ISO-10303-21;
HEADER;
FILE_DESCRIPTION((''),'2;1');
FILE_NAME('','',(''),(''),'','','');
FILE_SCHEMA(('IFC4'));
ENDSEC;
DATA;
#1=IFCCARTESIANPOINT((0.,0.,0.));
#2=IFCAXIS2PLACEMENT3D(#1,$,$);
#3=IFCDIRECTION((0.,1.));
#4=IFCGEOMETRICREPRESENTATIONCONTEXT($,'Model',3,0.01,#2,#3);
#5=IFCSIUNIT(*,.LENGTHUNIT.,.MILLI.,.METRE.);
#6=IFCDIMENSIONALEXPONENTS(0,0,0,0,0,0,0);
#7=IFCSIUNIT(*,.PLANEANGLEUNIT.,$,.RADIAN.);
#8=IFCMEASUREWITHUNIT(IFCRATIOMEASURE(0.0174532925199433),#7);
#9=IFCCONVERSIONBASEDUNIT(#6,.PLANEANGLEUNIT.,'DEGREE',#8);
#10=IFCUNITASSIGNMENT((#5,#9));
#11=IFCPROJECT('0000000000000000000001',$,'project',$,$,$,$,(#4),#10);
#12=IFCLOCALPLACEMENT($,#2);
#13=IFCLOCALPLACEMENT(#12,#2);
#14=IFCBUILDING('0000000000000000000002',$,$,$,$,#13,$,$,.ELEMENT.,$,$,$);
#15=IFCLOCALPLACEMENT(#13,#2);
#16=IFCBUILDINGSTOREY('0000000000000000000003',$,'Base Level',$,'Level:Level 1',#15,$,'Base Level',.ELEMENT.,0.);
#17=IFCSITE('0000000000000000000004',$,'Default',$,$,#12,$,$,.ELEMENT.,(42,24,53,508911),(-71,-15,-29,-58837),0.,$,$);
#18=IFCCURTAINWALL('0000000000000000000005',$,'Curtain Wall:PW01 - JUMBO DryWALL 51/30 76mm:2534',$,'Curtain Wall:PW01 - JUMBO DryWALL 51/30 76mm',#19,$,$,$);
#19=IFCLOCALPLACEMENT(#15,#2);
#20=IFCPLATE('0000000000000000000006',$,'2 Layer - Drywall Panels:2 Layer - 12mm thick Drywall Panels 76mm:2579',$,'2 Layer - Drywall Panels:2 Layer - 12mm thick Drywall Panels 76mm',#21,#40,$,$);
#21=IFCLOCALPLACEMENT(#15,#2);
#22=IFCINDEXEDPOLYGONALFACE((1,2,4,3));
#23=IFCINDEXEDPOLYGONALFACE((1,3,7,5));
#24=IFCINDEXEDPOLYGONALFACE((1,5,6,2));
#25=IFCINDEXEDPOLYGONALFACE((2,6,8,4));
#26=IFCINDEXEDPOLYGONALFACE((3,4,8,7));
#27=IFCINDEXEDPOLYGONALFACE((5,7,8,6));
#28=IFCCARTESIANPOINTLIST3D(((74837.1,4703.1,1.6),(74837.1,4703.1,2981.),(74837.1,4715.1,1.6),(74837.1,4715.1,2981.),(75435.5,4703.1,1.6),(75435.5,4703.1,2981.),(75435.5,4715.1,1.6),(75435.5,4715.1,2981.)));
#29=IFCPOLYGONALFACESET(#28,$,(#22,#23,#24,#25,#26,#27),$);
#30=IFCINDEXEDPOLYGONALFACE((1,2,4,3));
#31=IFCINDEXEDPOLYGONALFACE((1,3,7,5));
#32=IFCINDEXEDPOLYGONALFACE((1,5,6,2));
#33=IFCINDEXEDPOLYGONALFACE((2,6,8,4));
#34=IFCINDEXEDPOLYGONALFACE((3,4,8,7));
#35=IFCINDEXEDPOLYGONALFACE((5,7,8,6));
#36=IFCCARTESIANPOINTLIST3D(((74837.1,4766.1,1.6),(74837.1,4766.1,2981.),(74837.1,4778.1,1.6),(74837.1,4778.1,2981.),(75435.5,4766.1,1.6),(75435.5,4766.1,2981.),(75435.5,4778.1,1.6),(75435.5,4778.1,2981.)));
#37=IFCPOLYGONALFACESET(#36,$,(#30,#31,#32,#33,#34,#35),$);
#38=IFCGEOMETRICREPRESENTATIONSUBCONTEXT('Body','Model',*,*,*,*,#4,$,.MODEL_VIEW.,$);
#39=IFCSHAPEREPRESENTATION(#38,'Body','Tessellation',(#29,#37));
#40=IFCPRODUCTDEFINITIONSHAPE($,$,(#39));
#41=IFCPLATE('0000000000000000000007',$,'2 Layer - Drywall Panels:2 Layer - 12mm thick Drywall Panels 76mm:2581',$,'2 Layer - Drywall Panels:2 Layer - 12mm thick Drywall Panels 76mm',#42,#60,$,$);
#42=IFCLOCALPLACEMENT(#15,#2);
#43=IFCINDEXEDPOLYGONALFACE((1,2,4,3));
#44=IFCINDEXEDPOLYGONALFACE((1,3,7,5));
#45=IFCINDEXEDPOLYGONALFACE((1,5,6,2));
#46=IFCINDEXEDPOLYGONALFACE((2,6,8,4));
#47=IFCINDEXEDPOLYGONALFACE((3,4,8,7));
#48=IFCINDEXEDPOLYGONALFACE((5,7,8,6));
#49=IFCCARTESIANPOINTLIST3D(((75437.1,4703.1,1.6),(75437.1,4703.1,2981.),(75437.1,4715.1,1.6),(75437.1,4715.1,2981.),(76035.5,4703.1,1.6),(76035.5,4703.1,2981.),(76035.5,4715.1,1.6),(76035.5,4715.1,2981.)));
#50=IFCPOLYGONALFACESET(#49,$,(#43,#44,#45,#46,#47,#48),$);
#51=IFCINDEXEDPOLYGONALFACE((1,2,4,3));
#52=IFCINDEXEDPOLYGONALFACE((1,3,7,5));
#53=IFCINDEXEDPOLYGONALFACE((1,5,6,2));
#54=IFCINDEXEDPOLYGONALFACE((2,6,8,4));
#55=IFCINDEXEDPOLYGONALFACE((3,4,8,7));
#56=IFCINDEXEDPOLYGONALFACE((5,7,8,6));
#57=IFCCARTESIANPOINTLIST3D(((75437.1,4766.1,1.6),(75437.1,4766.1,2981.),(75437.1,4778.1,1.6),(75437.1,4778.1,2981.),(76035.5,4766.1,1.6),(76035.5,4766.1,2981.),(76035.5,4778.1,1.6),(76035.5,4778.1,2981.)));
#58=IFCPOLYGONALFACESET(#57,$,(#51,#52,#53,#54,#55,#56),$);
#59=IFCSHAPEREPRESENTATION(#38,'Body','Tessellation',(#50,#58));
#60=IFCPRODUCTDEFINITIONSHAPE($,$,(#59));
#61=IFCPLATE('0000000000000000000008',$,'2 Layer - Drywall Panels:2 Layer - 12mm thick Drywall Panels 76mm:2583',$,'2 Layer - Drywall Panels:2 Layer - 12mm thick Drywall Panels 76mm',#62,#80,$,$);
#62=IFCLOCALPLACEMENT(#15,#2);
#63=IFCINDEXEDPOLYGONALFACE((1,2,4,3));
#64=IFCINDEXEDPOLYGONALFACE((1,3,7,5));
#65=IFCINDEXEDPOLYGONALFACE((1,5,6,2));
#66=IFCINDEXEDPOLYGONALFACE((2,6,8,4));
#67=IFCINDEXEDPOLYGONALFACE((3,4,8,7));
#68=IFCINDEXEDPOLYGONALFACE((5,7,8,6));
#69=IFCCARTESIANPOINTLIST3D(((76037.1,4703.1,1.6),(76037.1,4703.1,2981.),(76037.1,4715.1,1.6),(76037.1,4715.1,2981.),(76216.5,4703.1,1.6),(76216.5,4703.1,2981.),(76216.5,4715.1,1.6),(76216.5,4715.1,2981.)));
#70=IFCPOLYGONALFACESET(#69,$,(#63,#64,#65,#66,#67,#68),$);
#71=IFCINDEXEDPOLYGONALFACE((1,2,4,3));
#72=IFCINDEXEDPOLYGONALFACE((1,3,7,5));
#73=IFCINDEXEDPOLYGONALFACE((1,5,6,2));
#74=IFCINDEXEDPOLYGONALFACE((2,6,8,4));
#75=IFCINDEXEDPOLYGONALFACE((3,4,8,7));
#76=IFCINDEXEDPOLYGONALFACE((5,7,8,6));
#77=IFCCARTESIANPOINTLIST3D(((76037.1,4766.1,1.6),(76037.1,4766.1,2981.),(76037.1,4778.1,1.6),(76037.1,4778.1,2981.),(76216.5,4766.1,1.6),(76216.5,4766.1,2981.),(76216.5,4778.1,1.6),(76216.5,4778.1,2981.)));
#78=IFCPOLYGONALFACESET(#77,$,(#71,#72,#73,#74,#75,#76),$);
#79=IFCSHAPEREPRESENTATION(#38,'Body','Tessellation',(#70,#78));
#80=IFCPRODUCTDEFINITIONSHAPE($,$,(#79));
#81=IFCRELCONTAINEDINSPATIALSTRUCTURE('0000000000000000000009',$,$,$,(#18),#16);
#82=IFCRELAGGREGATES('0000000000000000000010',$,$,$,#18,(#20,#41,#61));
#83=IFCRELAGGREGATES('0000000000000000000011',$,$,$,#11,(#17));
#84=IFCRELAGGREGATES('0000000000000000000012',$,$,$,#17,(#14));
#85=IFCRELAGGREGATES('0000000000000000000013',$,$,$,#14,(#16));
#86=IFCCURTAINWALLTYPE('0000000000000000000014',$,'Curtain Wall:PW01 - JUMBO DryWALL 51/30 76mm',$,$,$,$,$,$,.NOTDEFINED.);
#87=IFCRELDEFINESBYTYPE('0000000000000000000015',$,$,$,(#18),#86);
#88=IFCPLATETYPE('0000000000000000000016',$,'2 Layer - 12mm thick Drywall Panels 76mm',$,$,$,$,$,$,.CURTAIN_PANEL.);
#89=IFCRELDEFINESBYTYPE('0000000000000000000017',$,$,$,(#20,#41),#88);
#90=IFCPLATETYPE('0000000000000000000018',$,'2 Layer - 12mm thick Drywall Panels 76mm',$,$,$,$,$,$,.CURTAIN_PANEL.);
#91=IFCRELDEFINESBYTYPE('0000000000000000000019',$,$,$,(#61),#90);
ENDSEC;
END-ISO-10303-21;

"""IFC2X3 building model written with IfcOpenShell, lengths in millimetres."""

from ifc_helpers import new_model, entity, si_unit, converted_unit, direction, frame, frame_2d, origin, origin_2d_with_axis, place, context, subcontext, project, spatial, rectangle, extrude, source, transform, mapped, type_object, type_shapes, element, aggregate, save


model = new_model("IFC2X3")

# Units and contexts
model_context = context("Model", 3, precision=0.01, world=origin(), true_north=direction((0.0, 1.0)))
body_context = subcontext(model_context, "Body", "Model", "MODEL_VIEW")
ifc_project = project(units=[si_unit("LENGTHUNIT", "METRE", prefix="MILLI"), converted_unit("PLANEANGLEUNIT", "DEGREE", entity("IfcRatioMeasure", 0.0174532925199433), si_unit("PLANEANGLEUNIT", "RADIAN"), dimensions=[0, 0, 0, 0, 0, 0, 0])], contexts=[model_context])

# Site, building, storey
site_placement = place(None, origin())
site = spatial("IfcSite", under=ifc_project, at=site_placement, Name="Default", CompositionType="ELEMENT", RefLatitude=(42, 24, 53, 508911), RefLongitude=(-71, -15, -29, -58837), RefElevation=0.0)
building_placement = place(site_placement, origin())
building = spatial("IfcBuilding", under=site, at=building_placement, CompositionType="ELEMENT")
storey_placement = place(building_placement, origin())
storey = spatial("IfcBuildingStorey", under=building, at=storey_placement, Name="Base Level", ObjectType="Level:Level 1", LongName="Base Level", CompositionType="ELEMENT", Elevation=0.0)

# Curtain wall, plates
curtain_wall_type = type_object("IfcCurtainWallType", Name="Curtain Wall:PW01 - JUMBO DryWALL 51/30 76mm", PredefinedType="NOTDEFINED")
curtain_wall_placement = place(building_placement, origin())
curtain_wall = element("IfcCurtainWall", 1, at=curtain_wall_placement, inside=storey, type_object=curtain_wall_type, Name="Curtain Wall:PW01 - JUMBO DryWALL 51/30 76mm:2534", ObjectType="Curtain Wall:PW01 - JUMBO DryWALL 51/30 76mm")
plate_type_1 = type_object("IfcPlateType", Name="2 Layer - 12mm thick Drywall Panels 76mm", PredefinedType="CURTAIN_PANEL")
shared_shape_1 = source(origin(), body_context, "Body", "SweptSolid", [
    extrude(rectangle(XDim=598.4, YDim=12.0, at=origin_2d_with_axis()), frame((0.0, -31.5, 0.0), z_axis=(0.0, 0.0, 1.0), x_axis=(-1.0, 0.0, 0.0)), (0.0, 0.0, 1.0), 2979.4),
    extrude(rectangle(XDim=12.0, YDim=598.4, at=frame_2d((0.0, 0.0), x_axis=(1.0, 0.0))), frame((0.0, 31.5, 0.0), z_axis=(0.0, 0.0, 1.0), x_axis=(0.0, 1.0, 0.0)), (0.0, 0.0, 1.0), 2979.4),
])
type_shapes(plate_type_1, [shared_shape_1])
plate_1_placement = place(curtain_wall_placement, frame((75136.3, 4740.6, 1.6)))
plate_1 = element("IfcPlate", 2, at=plate_1_placement, type_object=plate_type_1, Name="2 Layer - Drywall Panels:2 Layer - 12mm thick Drywall Panels 76mm:2579", ObjectType="2 Layer - Drywall Panels:2 Layer - 12mm thick Drywall Panels 76mm", context=body_context, shape_type="MappedRepresentation", body=[
    mapped(shared_shape_1, transform((0.0, 0.0, 0.0), scale=1.0)),
])
plate_2_placement = place(curtain_wall_placement, frame((75736.3, 4740.6, 1.6)))
plate_2 = element("IfcPlate", 3, at=plate_2_placement, type_object=plate_type_1, Name="2 Layer - Drywall Panels:2 Layer - 12mm thick Drywall Panels 76mm:2581", ObjectType="2 Layer - Drywall Panels:2 Layer - 12mm thick Drywall Panels 76mm", context=body_context, shape_type="MappedRepresentation", body=[
    mapped(shared_shape_1, transform((0.0, 0.0, 0.0), scale=1.0)),
])
plate_type_2 = type_object("IfcPlateType", Name="2 Layer - 12mm thick Drywall Panels 76mm", PredefinedType="CURTAIN_PANEL")
shared_shape_2 = source(origin(), body_context, "Body", "SweptSolid", [
    extrude(rectangle(XDim=179.4, YDim=12.0, at=origin_2d_with_axis()), frame((0.0, -31.5, 0.0), z_axis=(0.0, 0.0, 1.0), x_axis=(-1.0, 0.0, 0.0)), (0.0, 0.0, 1.0), 2979.4),
    extrude(rectangle(XDim=12.0, YDim=179.4, at=frame_2d((0.0, 0.0), x_axis=(1.0, 0.0))), frame((0.0, 31.5, 0.0), z_axis=(0.0, 0.0, 1.0), x_axis=(0.0, 1.0, 0.0)), (0.0, 0.0, 1.0), 2979.4),
])
type_shapes(plate_type_2, [shared_shape_2])
plate_3_placement = place(curtain_wall_placement, frame((76126.8, 4740.6, 1.6)))
plate_3 = element("IfcPlate", 4, at=plate_3_placement, type_object=plate_type_2, Name="2 Layer - Drywall Panels:2 Layer - 12mm thick Drywall Panels 76mm:2583", ObjectType="2 Layer - Drywall Panels:2 Layer - 12mm thick Drywall Panels 76mm", context=body_context, shape_type="MappedRepresentation", body=[
    mapped(shared_shape_2, transform((0.0, 0.0, 0.0), scale=1.0)),
])
aggregate(curtain_wall, [plate_1, plate_2, plate_3])

save(model, "model.ifc")
